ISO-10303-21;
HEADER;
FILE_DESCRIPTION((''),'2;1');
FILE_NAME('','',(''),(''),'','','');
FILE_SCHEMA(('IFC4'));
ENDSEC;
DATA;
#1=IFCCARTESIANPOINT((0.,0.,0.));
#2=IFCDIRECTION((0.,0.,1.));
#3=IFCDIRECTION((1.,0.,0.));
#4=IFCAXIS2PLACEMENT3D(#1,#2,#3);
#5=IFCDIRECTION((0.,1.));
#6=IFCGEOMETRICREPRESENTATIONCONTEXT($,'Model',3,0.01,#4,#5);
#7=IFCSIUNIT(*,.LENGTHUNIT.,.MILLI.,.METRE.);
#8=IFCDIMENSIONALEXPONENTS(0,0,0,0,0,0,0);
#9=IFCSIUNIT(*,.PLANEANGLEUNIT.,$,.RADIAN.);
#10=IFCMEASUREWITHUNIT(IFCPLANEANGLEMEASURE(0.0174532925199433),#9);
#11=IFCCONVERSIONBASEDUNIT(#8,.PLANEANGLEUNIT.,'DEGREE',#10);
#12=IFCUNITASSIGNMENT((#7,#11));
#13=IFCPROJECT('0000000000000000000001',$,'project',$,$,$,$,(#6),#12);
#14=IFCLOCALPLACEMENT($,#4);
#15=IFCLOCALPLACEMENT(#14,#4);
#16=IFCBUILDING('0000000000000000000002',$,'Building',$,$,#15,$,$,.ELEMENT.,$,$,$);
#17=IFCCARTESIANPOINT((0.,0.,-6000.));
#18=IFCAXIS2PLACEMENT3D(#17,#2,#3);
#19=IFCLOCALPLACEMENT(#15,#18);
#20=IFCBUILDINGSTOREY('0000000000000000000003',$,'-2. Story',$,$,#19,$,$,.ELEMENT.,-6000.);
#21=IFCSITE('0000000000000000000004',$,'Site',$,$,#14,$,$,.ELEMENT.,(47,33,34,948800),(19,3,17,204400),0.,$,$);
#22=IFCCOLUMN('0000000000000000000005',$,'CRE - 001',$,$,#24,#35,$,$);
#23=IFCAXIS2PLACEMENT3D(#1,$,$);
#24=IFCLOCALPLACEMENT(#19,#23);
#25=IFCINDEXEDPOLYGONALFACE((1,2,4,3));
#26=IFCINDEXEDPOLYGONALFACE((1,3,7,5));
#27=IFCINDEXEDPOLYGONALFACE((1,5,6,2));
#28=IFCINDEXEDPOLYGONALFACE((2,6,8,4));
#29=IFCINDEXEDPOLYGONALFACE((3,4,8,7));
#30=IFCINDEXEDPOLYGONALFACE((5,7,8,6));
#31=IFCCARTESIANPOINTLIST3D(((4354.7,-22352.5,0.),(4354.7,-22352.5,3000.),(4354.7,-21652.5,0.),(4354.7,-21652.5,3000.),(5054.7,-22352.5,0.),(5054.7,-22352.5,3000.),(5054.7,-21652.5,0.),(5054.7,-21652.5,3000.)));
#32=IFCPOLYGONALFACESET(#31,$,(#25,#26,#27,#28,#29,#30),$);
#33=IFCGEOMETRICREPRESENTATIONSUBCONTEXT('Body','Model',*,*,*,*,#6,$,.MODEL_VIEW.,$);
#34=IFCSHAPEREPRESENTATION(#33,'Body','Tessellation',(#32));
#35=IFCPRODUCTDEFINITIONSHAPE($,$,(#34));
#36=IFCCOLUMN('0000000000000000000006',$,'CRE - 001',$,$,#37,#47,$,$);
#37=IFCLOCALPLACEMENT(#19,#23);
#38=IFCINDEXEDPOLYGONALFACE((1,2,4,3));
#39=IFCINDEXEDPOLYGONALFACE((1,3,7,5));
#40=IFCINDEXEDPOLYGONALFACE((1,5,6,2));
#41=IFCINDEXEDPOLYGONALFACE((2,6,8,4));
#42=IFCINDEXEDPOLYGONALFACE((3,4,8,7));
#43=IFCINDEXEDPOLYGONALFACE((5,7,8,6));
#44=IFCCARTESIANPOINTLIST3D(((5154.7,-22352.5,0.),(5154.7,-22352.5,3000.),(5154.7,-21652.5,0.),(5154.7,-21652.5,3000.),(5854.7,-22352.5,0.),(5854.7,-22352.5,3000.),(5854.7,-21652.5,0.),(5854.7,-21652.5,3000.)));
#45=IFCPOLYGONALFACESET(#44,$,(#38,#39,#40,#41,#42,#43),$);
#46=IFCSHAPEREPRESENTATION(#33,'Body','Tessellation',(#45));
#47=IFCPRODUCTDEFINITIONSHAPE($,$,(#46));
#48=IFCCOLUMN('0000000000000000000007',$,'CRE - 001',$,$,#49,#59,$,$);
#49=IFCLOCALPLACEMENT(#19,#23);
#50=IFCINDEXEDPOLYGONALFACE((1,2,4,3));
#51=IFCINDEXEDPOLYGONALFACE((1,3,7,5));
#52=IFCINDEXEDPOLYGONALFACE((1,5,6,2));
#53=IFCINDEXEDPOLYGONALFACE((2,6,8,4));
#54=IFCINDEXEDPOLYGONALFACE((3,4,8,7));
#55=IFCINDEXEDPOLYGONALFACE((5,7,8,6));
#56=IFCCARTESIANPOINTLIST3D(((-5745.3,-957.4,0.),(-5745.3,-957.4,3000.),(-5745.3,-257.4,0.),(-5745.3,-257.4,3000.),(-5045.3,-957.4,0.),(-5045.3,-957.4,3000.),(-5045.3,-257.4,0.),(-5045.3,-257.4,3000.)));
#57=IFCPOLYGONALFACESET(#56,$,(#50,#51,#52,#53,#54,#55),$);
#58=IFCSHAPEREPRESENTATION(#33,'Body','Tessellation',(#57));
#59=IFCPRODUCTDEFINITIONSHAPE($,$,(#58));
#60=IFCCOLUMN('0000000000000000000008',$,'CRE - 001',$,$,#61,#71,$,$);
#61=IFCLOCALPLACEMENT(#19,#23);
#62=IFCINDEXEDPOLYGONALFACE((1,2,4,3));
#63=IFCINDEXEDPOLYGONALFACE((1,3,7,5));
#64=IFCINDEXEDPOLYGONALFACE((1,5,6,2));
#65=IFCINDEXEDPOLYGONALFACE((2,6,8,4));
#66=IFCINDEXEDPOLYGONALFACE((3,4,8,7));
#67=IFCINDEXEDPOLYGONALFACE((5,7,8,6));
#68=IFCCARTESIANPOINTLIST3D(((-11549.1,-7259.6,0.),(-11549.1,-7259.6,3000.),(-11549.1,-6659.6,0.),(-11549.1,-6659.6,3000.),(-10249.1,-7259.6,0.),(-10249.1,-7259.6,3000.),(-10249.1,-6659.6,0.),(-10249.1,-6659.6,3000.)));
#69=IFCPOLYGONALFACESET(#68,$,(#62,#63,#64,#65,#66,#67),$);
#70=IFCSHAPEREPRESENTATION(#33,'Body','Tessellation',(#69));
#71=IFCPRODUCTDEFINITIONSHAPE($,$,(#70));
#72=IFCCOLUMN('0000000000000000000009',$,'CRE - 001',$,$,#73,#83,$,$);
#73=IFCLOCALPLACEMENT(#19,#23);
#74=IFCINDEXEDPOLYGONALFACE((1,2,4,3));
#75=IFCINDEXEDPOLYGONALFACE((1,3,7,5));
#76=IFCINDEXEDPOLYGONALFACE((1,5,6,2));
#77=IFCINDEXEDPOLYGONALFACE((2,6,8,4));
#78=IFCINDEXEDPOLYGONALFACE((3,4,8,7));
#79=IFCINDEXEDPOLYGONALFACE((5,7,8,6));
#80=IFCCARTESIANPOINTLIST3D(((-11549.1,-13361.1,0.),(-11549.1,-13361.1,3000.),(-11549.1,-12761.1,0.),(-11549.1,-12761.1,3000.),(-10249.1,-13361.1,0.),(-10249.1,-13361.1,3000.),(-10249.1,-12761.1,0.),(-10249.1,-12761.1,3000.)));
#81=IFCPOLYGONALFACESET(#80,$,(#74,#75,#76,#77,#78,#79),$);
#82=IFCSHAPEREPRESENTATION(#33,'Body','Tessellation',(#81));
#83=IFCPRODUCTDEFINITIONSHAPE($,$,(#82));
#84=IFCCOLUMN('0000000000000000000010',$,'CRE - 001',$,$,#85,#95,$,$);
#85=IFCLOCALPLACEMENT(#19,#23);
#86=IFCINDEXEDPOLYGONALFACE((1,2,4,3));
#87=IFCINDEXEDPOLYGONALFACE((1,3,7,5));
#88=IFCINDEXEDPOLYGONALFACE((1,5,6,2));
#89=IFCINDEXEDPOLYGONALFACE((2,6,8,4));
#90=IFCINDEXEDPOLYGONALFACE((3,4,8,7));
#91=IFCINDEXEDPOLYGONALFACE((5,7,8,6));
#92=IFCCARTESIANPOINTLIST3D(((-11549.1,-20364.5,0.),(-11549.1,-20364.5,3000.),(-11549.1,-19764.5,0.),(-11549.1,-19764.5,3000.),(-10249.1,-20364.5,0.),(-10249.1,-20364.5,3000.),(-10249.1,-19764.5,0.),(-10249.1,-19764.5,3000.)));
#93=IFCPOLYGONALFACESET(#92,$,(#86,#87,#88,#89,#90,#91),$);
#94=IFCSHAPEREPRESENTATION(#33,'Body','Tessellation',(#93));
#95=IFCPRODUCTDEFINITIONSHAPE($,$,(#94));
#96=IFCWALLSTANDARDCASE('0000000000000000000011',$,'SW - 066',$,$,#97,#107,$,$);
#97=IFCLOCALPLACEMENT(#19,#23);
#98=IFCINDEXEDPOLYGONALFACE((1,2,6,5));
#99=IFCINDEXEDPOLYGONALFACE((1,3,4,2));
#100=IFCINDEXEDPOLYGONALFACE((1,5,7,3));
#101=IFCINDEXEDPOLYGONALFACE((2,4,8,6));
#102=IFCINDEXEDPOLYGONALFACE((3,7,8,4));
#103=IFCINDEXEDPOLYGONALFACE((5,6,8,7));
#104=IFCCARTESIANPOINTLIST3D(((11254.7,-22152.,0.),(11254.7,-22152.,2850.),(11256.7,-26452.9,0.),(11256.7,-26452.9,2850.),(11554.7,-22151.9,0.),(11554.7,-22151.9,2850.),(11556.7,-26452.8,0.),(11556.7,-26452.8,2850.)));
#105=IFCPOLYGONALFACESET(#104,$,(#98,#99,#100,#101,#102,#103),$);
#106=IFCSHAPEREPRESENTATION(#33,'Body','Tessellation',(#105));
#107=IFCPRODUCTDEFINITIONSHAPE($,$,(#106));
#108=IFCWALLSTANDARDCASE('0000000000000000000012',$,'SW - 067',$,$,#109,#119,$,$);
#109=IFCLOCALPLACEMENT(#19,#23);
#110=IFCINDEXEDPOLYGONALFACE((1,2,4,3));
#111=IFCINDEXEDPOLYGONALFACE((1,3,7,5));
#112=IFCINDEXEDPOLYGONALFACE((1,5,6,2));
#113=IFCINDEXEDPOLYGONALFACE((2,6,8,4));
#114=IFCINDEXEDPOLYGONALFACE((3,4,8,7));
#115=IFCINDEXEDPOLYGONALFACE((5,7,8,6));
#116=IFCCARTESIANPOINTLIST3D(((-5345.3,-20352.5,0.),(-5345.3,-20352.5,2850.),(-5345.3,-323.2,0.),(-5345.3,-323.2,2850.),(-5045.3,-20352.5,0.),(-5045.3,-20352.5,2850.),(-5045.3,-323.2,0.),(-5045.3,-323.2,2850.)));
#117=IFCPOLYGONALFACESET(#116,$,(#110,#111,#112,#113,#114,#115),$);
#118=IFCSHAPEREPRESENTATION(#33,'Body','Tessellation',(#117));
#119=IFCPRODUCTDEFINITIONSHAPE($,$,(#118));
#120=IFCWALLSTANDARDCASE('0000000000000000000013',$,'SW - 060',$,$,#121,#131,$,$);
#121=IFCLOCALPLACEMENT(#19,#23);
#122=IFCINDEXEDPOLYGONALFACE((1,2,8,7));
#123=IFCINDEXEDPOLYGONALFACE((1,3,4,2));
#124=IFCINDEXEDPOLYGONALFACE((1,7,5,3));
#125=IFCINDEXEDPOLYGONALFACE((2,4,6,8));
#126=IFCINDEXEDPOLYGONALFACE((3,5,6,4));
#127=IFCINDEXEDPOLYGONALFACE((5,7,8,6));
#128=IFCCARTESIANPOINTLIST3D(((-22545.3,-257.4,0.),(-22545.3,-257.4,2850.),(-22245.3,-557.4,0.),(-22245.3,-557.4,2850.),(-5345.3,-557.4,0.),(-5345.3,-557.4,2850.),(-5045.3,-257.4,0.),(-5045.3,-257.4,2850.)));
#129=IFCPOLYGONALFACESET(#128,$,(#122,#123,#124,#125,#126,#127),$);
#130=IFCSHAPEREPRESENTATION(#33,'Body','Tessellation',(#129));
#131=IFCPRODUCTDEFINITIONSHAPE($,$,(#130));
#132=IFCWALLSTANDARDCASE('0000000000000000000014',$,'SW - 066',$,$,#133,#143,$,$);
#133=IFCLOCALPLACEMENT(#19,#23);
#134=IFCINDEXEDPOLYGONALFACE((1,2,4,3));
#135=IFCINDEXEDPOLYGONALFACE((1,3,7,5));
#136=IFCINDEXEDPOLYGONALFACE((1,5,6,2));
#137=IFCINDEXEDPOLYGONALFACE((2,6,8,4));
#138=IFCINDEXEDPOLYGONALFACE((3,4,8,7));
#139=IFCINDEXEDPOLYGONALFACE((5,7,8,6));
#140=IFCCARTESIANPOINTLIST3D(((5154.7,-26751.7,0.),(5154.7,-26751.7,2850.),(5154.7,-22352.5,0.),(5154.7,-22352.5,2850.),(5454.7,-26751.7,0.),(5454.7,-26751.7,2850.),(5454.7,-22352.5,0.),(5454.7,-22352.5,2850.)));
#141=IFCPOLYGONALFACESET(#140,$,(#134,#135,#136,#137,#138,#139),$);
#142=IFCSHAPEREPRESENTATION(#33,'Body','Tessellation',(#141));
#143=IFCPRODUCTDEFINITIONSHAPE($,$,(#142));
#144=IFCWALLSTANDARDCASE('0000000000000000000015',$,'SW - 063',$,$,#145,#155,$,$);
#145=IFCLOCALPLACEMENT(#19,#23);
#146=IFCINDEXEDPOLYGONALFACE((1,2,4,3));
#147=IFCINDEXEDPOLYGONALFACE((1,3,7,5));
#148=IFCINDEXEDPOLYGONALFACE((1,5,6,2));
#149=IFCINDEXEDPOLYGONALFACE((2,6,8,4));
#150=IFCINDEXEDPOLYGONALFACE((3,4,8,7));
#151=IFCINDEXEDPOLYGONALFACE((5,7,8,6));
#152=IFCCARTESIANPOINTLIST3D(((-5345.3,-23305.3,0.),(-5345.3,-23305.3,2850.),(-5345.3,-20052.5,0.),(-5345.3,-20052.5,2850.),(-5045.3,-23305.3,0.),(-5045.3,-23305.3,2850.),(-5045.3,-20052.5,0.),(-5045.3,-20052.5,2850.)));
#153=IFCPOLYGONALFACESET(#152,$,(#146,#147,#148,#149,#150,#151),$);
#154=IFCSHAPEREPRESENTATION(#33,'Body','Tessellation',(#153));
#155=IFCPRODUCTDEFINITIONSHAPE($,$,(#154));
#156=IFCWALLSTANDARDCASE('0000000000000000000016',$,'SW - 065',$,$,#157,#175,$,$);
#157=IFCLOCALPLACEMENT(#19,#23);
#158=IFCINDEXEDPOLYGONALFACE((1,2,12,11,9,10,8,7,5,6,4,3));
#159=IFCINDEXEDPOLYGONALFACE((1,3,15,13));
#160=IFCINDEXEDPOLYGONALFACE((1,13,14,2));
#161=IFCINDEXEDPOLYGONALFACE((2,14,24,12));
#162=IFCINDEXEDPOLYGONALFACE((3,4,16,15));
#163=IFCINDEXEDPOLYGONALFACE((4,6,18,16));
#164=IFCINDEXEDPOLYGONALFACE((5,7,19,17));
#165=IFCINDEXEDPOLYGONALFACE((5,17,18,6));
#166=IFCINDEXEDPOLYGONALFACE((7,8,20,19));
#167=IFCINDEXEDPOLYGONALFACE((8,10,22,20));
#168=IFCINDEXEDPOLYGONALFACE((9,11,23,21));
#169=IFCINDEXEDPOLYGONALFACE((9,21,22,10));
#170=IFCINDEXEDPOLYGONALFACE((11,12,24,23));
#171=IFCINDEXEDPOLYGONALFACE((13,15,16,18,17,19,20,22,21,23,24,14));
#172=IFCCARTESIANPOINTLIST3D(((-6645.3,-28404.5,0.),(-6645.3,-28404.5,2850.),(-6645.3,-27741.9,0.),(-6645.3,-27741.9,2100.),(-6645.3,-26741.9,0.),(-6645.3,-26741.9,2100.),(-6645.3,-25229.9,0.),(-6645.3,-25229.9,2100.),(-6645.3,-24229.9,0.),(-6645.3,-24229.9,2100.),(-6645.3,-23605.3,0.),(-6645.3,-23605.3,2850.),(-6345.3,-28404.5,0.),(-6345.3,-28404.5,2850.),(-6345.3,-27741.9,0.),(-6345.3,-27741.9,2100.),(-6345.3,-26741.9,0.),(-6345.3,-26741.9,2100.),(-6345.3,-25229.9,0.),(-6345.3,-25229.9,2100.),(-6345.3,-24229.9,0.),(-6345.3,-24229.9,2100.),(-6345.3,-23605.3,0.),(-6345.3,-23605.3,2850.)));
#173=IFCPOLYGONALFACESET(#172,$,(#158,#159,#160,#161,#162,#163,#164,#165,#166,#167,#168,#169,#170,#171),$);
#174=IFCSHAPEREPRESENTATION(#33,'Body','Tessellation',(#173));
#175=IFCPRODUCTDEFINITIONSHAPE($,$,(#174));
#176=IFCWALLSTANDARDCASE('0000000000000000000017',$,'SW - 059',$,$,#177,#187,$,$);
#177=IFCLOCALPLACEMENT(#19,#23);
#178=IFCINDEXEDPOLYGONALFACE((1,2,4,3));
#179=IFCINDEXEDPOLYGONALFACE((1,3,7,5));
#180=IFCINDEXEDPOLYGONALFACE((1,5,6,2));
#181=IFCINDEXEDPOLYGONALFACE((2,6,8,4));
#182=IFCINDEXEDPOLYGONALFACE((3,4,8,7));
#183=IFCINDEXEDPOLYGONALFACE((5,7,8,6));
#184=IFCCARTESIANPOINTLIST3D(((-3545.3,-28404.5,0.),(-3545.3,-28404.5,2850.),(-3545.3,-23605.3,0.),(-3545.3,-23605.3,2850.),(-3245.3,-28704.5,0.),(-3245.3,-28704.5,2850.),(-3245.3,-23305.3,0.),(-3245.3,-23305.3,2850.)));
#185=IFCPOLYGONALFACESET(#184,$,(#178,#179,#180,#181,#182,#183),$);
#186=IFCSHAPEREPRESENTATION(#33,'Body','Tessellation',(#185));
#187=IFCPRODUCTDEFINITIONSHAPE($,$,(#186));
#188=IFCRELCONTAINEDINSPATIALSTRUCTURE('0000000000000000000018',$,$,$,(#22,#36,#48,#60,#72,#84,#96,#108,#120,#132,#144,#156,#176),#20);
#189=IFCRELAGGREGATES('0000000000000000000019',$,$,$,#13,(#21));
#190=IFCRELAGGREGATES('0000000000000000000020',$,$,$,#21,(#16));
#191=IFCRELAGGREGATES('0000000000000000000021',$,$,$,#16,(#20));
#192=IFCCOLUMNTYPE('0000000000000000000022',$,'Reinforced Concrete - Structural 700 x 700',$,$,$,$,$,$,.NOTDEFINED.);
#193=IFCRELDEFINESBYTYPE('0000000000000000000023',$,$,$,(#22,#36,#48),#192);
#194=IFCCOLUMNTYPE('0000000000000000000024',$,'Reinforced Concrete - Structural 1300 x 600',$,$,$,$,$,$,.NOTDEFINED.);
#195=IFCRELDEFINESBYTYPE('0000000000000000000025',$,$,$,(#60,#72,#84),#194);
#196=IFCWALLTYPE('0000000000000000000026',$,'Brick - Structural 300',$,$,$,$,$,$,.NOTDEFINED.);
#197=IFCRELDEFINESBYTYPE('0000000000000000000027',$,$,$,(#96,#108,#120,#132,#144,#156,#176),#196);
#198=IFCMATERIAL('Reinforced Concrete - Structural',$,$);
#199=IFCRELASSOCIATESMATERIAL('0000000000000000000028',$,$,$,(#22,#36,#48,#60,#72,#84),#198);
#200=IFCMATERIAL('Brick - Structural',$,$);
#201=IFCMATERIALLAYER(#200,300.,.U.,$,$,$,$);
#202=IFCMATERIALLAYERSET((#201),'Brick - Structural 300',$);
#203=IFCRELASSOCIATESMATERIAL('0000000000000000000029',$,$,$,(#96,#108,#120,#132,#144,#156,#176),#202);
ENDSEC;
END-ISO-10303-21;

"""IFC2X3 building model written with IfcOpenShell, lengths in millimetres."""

from ifc_helpers import new_model, entity, si_unit, converted_unit, direction, frame, origin_with_axes, origin_2d_with_axis, place, context, subcontext, project, spatial, polyline, rectangle, outline, extrude, material, layer, layer_set, layer_usage, type_object, element, save


model = new_model("IFC2X3")

# Units and contexts
model_context = context("Model", 3, precision=0.01, world=origin_with_axes(), true_north=direction((0.0, 1.0)))
body_context = subcontext(model_context, "Body", "Model", "MODEL_VIEW")
ifc_project = project(units=[si_unit("LENGTHUNIT", "METRE", prefix="MILLI"), converted_unit("PLANEANGLEUNIT", "DEGREE", entity("IfcPlaneAngleMeasure", 0.0174532925199433), si_unit("PLANEANGLEUNIT", "RADIAN"), dimensions=[0, 0, 0, 0, 0, 0, 0])], contexts=[model_context])

# Site, building, storey
site_placement = place(None, origin_with_axes())
site = spatial("IfcSite", under=ifc_project, at=site_placement, Name="Site", CompositionType="ELEMENT", RefLatitude=(47, 33, 34, 948800), RefLongitude=(19, 3, 17, 204400), RefElevation=0.0)
building_placement = place(site_placement, origin_with_axes())
building = spatial("IfcBuilding", under=site, at=building_placement, Name="Building", CompositionType="ELEMENT")
storey_placement = place(building_placement, frame((0.0, 0.0, -6000.0), z_axis=(0.0, 0.0, 1.0), x_axis=(1.0, 0.0, 0.0)))
storey = spatial("IfcBuildingStorey", under=building, at=storey_placement, Name="-2. Story", CompositionType="ELEMENT", Elevation=-6000.0)

# Columns
ifc_material_1 = material(Name="Reinforced Concrete - Structural")
column_type_1 = type_object("IfcColumnType", Name="Reinforced Concrete - Structural 700 x 700", PredefinedType="NOTDEFINED")
for number, where, z_axis, x_axis, name in (
    (1, (4704.7, -22002.5, 0.0), (0.0, 0.0, 1.0), (1.0, 0.0, 0.0), "CRE - 001"),
    (2, (5504.7, -22002.5, 0.0), (0.0, 0.0, 1.0), (1.0, 0.0, 0.0), "CRE - 001"),
    (3, (-5395.3, -607.4, 0.0), (0.0, 0.0, 1.0), (1.0, 0.0, 0.0), "CRE - 001"),
):
    element("IfcColumn", number, at=place(storey_placement, frame(where, z_axis=z_axis, x_axis=x_axis)), inside=storey, type_object=column_type_1, material=ifc_material_1, Name=name, context=body_context, shape_type="SweptSolid", body=[
        extrude(rectangle(XDim=700.0, YDim=700.0, at=origin_2d_with_axis()), origin_with_axes(), (0.0, 0.0, 1.0), 3000.0),
    ])
column_type_2 = type_object("IfcColumnType", Name="Reinforced Concrete - Structural 1300 x 600", PredefinedType="NOTDEFINED")
for number, where, z_axis, x_axis, name in (
    (4, (-10899.1, -6959.6, 0.0), (0.0, 0.0, 1.0), (1.0, 0.0, 0.0), "CRE - 001"),
    (5, (-10899.1, -13061.1, 0.0), (0.0, 0.0, 1.0), (1.0, 0.0, 0.0), "CRE - 001"),
    (6, (-10899.1, -20064.5, 0.0), (0.0, 0.0, 1.0), (1.0, 0.0, 0.0), "CRE - 001"),
):
    element("IfcColumn", number, at=place(storey_placement, frame(where, z_axis=z_axis, x_axis=x_axis)), inside=storey, type_object=column_type_2, material=ifc_material_1, Name=name, context=body_context, shape_type="SweptSolid", body=[
        extrude(rectangle(XDim=1300.0, YDim=600.0, at=origin_2d_with_axis()), origin_with_axes(), (0.0, 0.0, 1.0), 3000.0),
    ])

# Walls
ifc_material_2 = material(Name="Brick - Structural")
ifc_layer_1 = layer(ifc_material_2, 300.0, ventilated="UNKNOWN")
ifc_layer_set_1 = layer_set([ifc_layer_1], Name="Brick - Structural 300")
ifc_layer_usage_1 = layer_usage(ifc_layer_set_1, "AXIS2", "POSITIVE", 0.0)
wall_type_1 = type_object("IfcWallType", Name="Brick - Structural 300", PredefinedType="NOTDEFINED")
wall_1_placement = place(storey_placement, frame((11254.7, -22152.0, 0.0), z_axis=(0.0, 0.0, 1.0), x_axis=(0.000477, -1.0, 0.0)))
element("IfcWallStandardCase", 7, at=wall_1_placement, inside=storey, type_object=wall_type_1, material=ifc_layer_usage_1, Name="SW - 066", context=body_context, shape_type="SweptSolid", body=[
    extrude(outline(polyline([(0.0, 0.0), (4300.9, 0.0), (4300.9, 300.0), (0.0, 300.0), (0.0, 0.0)])), origin_with_axes(), (0.0, 0.0, 1.0), 2850.0),
])
ifc_layer_usage_2 = layer_usage(ifc_layer_set_1, "AXIS2", "POSITIVE", 0.0)
wall_2_placement = place(storey_placement, frame((-5045.3, -20352.5, 0.0), z_axis=(0.0, 0.0, 1.0), x_axis=(0.0, 1.0, 0.0)))
element("IfcWallStandardCase", 8, at=wall_2_placement, inside=storey, type_object=wall_type_1, material=ifc_layer_usage_2, Name="SW - 067", context=body_context, shape_type="SweptSolid", body=[
    extrude(outline(polyline([(0.0, 0.0), (20029.3, 0.0), (20029.3, 300.0), (0.0, 300.0), (0.0, 0.0)])), origin_with_axes(), (0.0, 0.0, 1.0), 2850.0),
])
ifc_layer_usage_3 = layer_usage(ifc_layer_set_1, "AXIS2", "POSITIVE", 0.0)
wall_3_placement = place(storey_placement, frame((-5045.3, -257.4, 0.0), z_axis=(0.0, 0.0, 1.0), x_axis=(-1.0, 0.0, 0.0)))
element("IfcWallStandardCase", 9, at=wall_3_placement, inside=storey, type_object=wall_type_1, material=ifc_layer_usage_3, Name="SW - 060", context=body_context, shape_type="SweptSolid", body=[
    extrude(outline(polyline([(0.0, 0.0), (17500.0, 0.0), (17200.0, 300.0), (300.0, 300.0), (0.0, 0.0)])), origin_with_axes(), (0.0, 0.0, 1.0), 2850.0),
])
ifc_layer_usage_4 = layer_usage(ifc_layer_set_1, "AXIS2", "POSITIVE", 0.0)
wall_4_placement = place(storey_placement, frame((5154.7, -22352.5, 0.0), z_axis=(0.0, 0.0, 1.0), x_axis=(0.0, -1.0, 0.0)))
element("IfcWallStandardCase", 10, at=wall_4_placement, inside=storey, type_object=wall_type_1, material=ifc_layer_usage_4, Name="SW - 066", context=body_context, shape_type="SweptSolid", body=[
    extrude(outline(polyline([(0.0, 0.0), (4399.2, 0.0), (4399.2, 300.0), (0.0, 300.0), (0.0, 0.0)])), origin_with_axes(), (0.0, 0.0, 1.0), 2850.0),
])
ifc_layer_usage_5 = layer_usage(ifc_layer_set_1, "AXIS2", "NEGATIVE", 0.0)
wall_5_placement = place(storey_placement, frame((-5045.3, -20052.5, 0.0), z_axis=(0.0, 0.0, 1.0), x_axis=(0.0, -1.0, 0.0)))
element("IfcWallStandardCase", 11, at=wall_5_placement, inside=storey, type_object=wall_type_1, material=ifc_layer_usage_5, Name="SW - 063", context=body_context, shape_type="SweptSolid", body=[
    extrude(outline(polyline([(0.0, -300.0), (3252.7, -300.0), (3252.7, 0.0), (0.0, 0.0), (0.0, -300.0)])), origin_with_axes(), (0.0, 0.0, 1.0), 2850.0),
])

# Wall, openings
ifc_layer_usage_6 = layer_usage(ifc_layer_set_1, "AXIS2", "POSITIVE", 0.0)
wall_6_placement = place(storey_placement, frame((-6645.3, -23305.3, 0.0), z_axis=(0.0, 0.0, 1.0), x_axis=(0.0, -1.0, 0.0)))
wall_6 = element("IfcWallStandardCase", 12, at=wall_6_placement, inside=storey, type_object=wall_type_1, material=ifc_layer_usage_6, Name="SW - 065", context=body_context, shape_type="SweptSolid", body=[
    extrude(outline(polyline([(300.0, 0.0), (5099.2, 0.0), (5099.2, 300.0), (300.0, 300.0), (300.0, 0.0)])), origin_with_axes(), (0.0, 0.0, 1.0), 2850.0),
])
opening_1_placement = place(wall_6_placement, frame((1424.6, 0.0, 0.0), z_axis=(0.0, 0.0, 1.0), x_axis=(1.0, 0.0, 0.0)))
element("IfcOpeningElement", 13, at=opening_1_placement, cuts=wall_6, context=body_context, shape_type="SweptSolid", body=[
    extrude(rectangle(XDim=1000.0, YDim=2100.0, at=origin_2d_with_axis()), frame((0.0, 0.0, 1050.0), z_axis=(0.0, 1.0, 0.0), x_axis=(1.0, 0.0, 0.0)), (0.0, 0.0, -1.0), 300.0),
    extrude(rectangle(XDim=1000.0, YDim=2100.0, at=origin_2d_with_axis()), frame((0.0, 0.0, 1050.0), z_axis=(0.0, -1.0, 0.0), x_axis=(1.0, 0.0, 0.0)), (0.0, 0.0, -1.0), 300.0),
])
opening_2_placement = place(wall_6_placement, frame((3936.7, 0.0, 0.0), z_axis=(0.0, 0.0, 1.0), x_axis=(1.0, 0.0, 0.0)))
element("IfcOpeningElement", 14, at=opening_2_placement, cuts=wall_6, context=body_context, shape_type="SweptSolid", body=[
    extrude(rectangle(XDim=1000.0, YDim=2100.0, at=origin_2d_with_axis()), frame((0.0, 300.0, 1050.0), z_axis=(0.0, -1.0, 0.0), x_axis=(1.0, 0.0, 0.0)), (0.0, 0.0, -1.0), 300.0),
    extrude(rectangle(XDim=1000.0, YDim=2100.0, at=origin_2d_with_axis()), frame((0.0, 300.0, 1050.0), z_axis=(0.0, 1.0, 0.0), x_axis=(1.0, 0.0, 0.0)), (0.0, 0.0, -1.0), 300.0),
])

# Wall
ifc_layer_usage_7 = layer_usage(ifc_layer_set_1, "AXIS2", "NEGATIVE", 0.0)
wall_7_placement = place(storey_placement, frame((-3245.3, -23305.3, 0.0), z_axis=(0.0, 0.0, 1.0), x_axis=(0.0, -1.0, 0.0)))
element("IfcWallStandardCase", 15, at=wall_7_placement, inside=storey, type_object=wall_type_1, material=ifc_layer_usage_7, Name="SW - 059", context=body_context, shape_type="SweptSolid", body=[
    extrude(outline(polyline([(300.0, -300.0), (5099.2, -300.0), (5399.2, 0.0), (0.0, 0.0), (300.0, -300.0)])), origin_with_axes(), (0.0, 0.0, 1.0), 2850.0),
])

save(model, "model.ifc")
